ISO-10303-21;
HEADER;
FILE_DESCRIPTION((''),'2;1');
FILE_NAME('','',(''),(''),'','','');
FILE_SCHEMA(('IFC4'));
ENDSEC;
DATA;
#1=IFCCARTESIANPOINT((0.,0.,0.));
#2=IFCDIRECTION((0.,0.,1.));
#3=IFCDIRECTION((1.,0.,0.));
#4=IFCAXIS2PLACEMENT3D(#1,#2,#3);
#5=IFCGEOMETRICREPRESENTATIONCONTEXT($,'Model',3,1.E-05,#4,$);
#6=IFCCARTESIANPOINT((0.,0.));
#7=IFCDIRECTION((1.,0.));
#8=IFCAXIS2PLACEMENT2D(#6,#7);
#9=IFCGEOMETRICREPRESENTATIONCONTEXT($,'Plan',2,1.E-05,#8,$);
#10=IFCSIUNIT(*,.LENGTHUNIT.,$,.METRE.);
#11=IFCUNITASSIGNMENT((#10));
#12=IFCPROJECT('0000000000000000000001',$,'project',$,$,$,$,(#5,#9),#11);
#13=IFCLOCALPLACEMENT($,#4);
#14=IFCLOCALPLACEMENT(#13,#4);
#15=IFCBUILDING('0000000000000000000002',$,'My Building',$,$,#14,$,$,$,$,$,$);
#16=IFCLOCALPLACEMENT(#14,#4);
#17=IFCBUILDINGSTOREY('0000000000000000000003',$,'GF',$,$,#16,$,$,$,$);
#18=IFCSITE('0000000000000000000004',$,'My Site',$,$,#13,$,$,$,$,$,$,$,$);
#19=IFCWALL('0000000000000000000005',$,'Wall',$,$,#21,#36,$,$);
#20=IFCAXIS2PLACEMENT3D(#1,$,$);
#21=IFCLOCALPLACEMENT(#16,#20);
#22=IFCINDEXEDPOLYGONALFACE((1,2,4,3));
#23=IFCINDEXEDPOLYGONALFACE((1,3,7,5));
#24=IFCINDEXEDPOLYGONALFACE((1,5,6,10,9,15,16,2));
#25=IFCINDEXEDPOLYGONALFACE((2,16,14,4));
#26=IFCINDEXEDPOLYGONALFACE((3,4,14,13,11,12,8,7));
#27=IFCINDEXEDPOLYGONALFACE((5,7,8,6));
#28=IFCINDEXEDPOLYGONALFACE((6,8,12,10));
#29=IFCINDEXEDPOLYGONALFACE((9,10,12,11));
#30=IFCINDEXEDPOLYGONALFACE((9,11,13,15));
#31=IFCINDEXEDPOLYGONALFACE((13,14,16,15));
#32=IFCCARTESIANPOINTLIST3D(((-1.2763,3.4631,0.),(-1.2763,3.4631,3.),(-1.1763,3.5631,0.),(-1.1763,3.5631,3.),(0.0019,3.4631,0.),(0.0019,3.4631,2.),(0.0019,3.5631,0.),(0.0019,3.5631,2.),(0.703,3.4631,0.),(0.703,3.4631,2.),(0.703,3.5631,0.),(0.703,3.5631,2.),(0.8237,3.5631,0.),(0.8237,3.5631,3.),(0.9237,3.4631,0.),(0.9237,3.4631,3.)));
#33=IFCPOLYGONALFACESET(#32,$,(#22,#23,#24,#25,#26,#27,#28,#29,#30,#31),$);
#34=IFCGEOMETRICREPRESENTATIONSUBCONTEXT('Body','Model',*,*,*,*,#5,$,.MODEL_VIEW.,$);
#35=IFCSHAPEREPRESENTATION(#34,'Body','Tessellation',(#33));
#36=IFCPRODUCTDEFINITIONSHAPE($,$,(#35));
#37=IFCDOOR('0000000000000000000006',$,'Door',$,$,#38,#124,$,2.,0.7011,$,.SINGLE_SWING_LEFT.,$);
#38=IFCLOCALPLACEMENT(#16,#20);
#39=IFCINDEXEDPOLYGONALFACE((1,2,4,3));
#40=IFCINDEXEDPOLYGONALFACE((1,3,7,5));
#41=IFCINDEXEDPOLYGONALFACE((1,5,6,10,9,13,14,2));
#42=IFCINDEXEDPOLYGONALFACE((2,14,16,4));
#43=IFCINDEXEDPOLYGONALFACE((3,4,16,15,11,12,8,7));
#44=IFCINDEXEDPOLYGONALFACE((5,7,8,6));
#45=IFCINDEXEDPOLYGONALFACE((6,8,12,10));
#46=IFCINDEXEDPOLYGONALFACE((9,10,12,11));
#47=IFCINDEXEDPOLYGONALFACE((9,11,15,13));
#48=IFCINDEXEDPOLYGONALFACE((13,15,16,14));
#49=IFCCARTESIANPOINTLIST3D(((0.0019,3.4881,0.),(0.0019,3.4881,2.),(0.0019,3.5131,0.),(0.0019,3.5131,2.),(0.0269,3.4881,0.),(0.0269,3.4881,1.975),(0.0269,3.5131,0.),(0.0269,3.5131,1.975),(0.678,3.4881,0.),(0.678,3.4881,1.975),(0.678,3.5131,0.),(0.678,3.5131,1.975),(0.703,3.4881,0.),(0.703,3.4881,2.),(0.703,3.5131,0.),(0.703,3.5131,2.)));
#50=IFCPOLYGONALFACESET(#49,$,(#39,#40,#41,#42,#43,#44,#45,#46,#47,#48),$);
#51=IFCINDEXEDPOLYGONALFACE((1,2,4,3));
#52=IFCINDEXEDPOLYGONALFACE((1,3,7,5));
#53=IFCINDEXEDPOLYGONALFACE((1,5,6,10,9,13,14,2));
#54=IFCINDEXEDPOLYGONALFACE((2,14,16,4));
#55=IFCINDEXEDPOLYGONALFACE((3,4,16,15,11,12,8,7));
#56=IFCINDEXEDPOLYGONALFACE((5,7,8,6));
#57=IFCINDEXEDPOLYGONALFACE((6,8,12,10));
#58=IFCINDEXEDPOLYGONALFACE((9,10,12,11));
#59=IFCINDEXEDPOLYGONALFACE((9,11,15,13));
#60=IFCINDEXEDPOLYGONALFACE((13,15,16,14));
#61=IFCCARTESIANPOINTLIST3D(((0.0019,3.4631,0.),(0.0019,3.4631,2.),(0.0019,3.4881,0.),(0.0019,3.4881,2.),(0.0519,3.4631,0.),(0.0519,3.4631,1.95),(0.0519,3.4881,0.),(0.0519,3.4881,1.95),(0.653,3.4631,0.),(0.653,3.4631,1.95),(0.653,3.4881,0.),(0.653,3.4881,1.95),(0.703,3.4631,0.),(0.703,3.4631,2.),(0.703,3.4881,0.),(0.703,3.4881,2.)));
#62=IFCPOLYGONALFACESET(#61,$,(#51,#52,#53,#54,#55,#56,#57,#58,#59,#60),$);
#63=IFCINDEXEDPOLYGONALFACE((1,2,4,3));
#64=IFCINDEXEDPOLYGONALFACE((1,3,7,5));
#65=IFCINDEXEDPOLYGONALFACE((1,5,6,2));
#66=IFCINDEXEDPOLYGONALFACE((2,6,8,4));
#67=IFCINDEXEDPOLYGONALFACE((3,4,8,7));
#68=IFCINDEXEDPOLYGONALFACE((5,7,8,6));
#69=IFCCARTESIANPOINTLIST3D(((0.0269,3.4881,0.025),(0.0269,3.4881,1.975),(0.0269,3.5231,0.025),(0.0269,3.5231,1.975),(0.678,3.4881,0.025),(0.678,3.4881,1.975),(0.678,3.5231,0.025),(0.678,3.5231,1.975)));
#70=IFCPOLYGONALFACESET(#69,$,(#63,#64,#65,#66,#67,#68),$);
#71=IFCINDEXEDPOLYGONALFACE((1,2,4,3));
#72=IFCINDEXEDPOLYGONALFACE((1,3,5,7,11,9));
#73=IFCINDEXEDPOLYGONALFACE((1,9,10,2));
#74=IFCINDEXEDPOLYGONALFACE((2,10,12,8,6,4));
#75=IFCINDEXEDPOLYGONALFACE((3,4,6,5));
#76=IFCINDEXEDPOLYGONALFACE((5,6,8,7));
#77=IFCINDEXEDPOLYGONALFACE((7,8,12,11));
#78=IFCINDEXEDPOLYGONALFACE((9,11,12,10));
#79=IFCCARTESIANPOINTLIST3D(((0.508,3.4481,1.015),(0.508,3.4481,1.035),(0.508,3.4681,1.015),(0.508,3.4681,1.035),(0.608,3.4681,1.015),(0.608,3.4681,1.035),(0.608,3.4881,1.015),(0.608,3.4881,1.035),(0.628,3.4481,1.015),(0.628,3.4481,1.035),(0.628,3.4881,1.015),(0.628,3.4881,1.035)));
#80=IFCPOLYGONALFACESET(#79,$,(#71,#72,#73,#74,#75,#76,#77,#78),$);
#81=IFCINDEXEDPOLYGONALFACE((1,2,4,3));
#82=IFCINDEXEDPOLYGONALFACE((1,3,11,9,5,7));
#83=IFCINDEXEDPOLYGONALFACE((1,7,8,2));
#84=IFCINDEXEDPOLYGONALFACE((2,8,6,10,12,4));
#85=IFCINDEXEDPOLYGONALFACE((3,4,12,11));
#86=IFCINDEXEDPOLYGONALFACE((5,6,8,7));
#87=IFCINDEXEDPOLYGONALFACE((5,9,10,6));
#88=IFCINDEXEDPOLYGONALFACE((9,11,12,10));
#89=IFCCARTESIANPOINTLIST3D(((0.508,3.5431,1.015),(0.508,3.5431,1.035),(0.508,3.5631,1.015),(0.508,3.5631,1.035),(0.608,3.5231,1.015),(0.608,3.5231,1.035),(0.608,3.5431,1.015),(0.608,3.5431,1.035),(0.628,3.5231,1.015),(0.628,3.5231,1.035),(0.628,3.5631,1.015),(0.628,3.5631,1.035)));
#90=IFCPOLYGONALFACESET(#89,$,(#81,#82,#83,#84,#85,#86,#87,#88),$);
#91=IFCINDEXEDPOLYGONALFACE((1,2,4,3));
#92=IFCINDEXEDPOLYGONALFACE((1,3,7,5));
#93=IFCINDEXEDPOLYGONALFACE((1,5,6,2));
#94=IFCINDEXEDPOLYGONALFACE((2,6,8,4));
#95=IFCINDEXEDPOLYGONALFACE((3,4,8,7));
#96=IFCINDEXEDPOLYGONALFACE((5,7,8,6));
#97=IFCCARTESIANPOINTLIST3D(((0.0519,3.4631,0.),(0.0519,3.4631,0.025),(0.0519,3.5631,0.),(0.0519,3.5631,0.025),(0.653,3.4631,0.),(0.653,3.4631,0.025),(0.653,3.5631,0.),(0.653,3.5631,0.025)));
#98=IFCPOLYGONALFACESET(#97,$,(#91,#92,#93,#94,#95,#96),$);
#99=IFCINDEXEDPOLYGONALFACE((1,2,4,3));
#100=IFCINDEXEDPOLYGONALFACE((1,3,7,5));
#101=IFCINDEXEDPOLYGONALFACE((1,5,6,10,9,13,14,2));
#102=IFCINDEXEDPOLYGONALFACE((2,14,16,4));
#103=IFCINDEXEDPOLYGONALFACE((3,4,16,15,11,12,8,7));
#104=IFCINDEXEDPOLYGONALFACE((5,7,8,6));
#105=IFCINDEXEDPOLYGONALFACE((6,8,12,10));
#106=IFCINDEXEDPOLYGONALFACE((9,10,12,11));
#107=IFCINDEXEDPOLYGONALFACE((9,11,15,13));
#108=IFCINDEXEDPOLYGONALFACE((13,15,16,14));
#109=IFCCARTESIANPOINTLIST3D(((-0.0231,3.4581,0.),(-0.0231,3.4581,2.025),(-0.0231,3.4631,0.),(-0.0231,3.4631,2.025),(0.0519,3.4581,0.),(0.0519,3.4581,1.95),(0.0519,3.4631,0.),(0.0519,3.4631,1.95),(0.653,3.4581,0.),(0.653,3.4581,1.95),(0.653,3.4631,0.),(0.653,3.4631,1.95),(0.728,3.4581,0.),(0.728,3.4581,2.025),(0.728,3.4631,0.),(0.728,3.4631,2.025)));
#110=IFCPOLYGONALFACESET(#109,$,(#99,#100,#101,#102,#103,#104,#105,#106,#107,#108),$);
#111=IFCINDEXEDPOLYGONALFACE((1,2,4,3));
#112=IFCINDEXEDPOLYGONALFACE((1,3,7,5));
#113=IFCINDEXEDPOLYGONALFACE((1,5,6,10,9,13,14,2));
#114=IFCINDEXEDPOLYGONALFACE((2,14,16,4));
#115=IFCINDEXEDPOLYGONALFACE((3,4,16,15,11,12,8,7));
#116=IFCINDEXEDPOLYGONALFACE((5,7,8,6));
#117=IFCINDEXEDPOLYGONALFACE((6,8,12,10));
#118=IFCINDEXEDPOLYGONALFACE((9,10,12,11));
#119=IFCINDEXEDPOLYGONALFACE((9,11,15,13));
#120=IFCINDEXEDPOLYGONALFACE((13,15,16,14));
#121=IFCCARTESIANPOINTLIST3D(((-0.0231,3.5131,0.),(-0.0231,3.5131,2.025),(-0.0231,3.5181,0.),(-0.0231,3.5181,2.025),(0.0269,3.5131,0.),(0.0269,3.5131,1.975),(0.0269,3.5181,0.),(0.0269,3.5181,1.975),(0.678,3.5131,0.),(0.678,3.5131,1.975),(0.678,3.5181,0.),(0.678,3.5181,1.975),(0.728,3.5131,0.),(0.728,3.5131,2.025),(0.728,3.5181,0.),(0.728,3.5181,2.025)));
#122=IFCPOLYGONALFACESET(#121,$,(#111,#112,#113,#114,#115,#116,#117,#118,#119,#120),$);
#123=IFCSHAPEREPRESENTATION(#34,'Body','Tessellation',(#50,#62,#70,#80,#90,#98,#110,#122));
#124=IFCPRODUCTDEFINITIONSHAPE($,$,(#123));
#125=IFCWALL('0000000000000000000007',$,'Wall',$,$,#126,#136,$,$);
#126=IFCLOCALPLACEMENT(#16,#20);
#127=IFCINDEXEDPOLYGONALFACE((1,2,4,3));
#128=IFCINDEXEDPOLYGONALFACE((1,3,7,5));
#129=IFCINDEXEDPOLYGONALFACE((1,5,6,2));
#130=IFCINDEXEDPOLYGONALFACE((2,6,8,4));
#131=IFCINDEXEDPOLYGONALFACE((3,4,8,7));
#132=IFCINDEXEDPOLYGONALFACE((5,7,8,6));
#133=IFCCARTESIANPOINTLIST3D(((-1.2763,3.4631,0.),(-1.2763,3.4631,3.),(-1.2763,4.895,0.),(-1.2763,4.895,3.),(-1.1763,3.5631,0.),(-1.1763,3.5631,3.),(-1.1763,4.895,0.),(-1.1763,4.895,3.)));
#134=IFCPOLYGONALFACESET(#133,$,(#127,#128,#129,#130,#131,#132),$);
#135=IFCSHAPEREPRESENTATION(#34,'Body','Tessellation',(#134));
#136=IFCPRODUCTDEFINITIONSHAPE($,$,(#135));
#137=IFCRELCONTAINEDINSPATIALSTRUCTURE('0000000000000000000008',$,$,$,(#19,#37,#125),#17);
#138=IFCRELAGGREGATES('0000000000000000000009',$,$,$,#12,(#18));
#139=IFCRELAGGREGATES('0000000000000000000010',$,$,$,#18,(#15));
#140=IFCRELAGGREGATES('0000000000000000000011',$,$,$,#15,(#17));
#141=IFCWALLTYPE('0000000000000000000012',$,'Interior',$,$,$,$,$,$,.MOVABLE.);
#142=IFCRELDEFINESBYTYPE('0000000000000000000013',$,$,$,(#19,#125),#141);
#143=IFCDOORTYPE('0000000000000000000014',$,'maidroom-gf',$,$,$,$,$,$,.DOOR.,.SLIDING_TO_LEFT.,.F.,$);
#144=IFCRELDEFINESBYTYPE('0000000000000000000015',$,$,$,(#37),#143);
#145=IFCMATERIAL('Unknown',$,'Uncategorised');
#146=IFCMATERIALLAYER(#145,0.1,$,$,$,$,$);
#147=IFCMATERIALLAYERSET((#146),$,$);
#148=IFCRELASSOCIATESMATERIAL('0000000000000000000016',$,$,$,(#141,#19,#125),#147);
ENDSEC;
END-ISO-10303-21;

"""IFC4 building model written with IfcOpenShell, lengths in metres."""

from ifc_helpers import new_model, entity, si_unit, frame, origin_with_axes, origin_2d_with_axis, place, context, subcontext, project, spatial, line, indexed_curve, outline, extrude, shape, source, transform, mapped, material, layer, layer_set, layer_usage, type_object, type_shapes, element, fill, save


model = new_model("IFC4")

# Units and contexts
model_context = context("Model", 3, precision=1e-05, world=origin_with_axes())
plan_context = context("Plan", 2, precision=1e-05, world=origin_2d_with_axis())
body_context_1 = subcontext(model_context, "Body", "Model", "MODEL_VIEW")
body_context_2 = subcontext(plan_context, "Body", "Plan", "PLAN_VIEW")
ifc_project = project(units=[si_unit("LENGTHUNIT", "METRE")], contexts=[model_context, plan_context])

# Site, building, storey
site_placement = place(None, origin_with_axes())
site = spatial("IfcSite", under=ifc_project, at=site_placement, Name="My Site")
building_placement = place(site_placement, origin_with_axes())
building = spatial("IfcBuilding", under=site, at=building_placement, Name="My Building")
storey_placement = place(building_placement, origin_with_axes())
storey = spatial("IfcBuildingStorey", under=building, at=storey_placement, Name="GF")

# Shared definitions
ifc_material = material(Name="Unknown", Category="Uncategorised")

# Shared definitions
ifc_layer_1 = layer(ifc_material, 0.1)
ifc_layer_set_1 = layer_set([ifc_layer_1])
wall_type_1 = type_object("IfcWallType", Name="Interior", PredefinedType="MOVABLE", material=ifc_layer_set_1)

# Wall, opening, door
ifc_layer_usage_1 = layer_usage(ifc_layer_set_1, "AXIS2", "POSITIVE", 0.0)
wall_1_placement = place(storey_placement, frame((0.8237, 3.5631, 0.0), z_axis=(0.0, 0.0, 1.0), x_axis=(-1.0, 0.0, 0.0)))
wall_1 = element("IfcWall", 1, at=wall_1_placement, inside=storey, type_object=wall_type_1, material=ifc_layer_usage_1, Name="Wall", context=body_context_1, shape_type="SweptSolid", body=[
    extrude(outline(indexed_curve([(0.0, 0.0), (-0.1, 0.1), (2.1, 0.1), (2.0, 0.0)], segments=[line(1, 2, 3, 4, 1)])), origin_with_axes(), (0.0, 0.0, 1.0), 3.0),
])
shared_shape_1 = source(origin_with_axes(), body_context_1, "Body", "SweptSolid", [
    extrude(outline(indexed_curve([(0.0, 0.0), (0.7011, 0.0), (0.7011, 2.0), (0.0, 2.0)], segments=[line(1, 2, 3, 4, 1)])), frame((0.0, -0.6, 0.0), z_axis=(0.0, -1.0, 0.0), x_axis=(1.0, 0.0, 0.0)), (0.0, 0.0, -1.0), 1.2),
])
opening_1_placement = place(wall_1_placement, frame((0.8218, 0.1, 0.0), z_axis=(0.0, 0.0, 1.0), x_axis=(-1.0, 0.0, 0.0)))
opening_1 = element("IfcOpeningElement", 2, at=opening_1_placement, cuts=wall_1, PredefinedType="OPENING", context=body_context_1, shape_type="MappedRepresentation", body=[
    mapped(shared_shape_1, transform((0.0, 0.0, 0.0), x_axis=(1.0, 0.0, 0.0), y_axis=(0.0, 1.0, 0.0), z_axis=(0.0, 0.0, 1.0), scale=1.0)),
])
door_type_1 = type_object("IfcDoorType", Name="maidroom-gf", OperationType="SLIDING_TO_LEFT", ParameterTakesPrecedence=False, PredefinedType="DOOR")
shared_shape_2 = source(origin_with_axes(), body_context_1, "Body", "SweptSolid", [
    extrude(outline(indexed_curve([(0.0, 0.0), (0.0, 2.0), (0.7011, 2.0), (0.7011, 0.0), (0.6761, 0.0), (0.6761, 1.975), (0.025, 1.975), (0.025, 0.0)], segments=[line(1, 2, 3, 4, 5, 6, 7, 8, 1)])), frame((0.0, 0.025, 0.0), z_axis=(0.0, -1.0, 0.0), x_axis=(1.0, 0.0, 0.0)), (0.0, 0.0, -1.0), 0.025),
    extrude(outline(indexed_curve([(0.0, 0.0), (0.0, 2.0), (0.7011, 2.0), (0.7011, 0.0), (0.6511, 0.0), (0.6511, 1.95), (0.05, 1.95), (0.05, 0.0)], segments=[line(1, 2, 3, 4, 5, 6, 7, 8, 1)])), frame((0.0, 0.0, 0.0), z_axis=(0.0, -1.0, 0.0), x_axis=(1.0, 0.0, 0.0)), (0.0, 0.0, -1.0), 0.025),
    extrude(outline(indexed_curve([(0.0, 0.0), (0.6511, 0.0), (0.6511, 0.035), (0.0, 0.035)], segments=[line(1, 2, 3, 4, 1)])), frame((0.025, 0.025, 0.025), z_axis=(0.0, 0.0, 1.0), x_axis=(1.0, 0.0, 0.0)), (0.0, 0.0, 1.0), 1.95),
    extrude(outline(indexed_curve([(0.0, 0.0), (0.0, -0.04), (-0.12, -0.04), (-0.12, -0.02), (-0.02, -0.02), (-0.02, 0.0)], segments=[line(1, 2, 3, 4, 5, 6, 1)])), frame((0.6261, 0.025, 1.015), z_axis=(0.0, 0.0, 1.0), x_axis=(1.0, 0.0, 0.0)), (0.0, 0.0, 1.0), 0.02),
    extrude(outline(indexed_curve([(0.0, 0.0), (0.0, 0.04), (-0.12, 0.04), (-0.12, 0.02), (-0.02, 0.02), (-0.02, 0.0)], segments=[line(1, 2, 3, 4, 5, 6, 1)])), frame((0.6261, 0.06, 1.015), z_axis=(0.0, 0.0, 1.0), x_axis=(1.0, 0.0, 0.0)), (0.0, 0.0, 1.0), 0.02),
    extrude(outline(indexed_curve([(0.0, 0.0), (0.6011, 0.0), (0.6011, 0.1), (0.0, 0.1)], segments=[line(1, 2, 3, 4, 1)])), frame((0.05, 0.0, 0.0), z_axis=(0.0, 0.0, 1.0), x_axis=(1.0, 0.0, 0.0)), (0.0, 0.0, 1.0), 0.025),
    extrude(outline(indexed_curve([(0.0, 0.0), (0.0, 2.025), (0.7511, 2.025), (0.7511, 0.0), (0.6761, 0.0), (0.6761, 1.95), (0.075, 1.95), (0.075, 0.0)], segments=[line(1, 2, 3, 4, 5, 6, 7, 8, 1)])), frame((-0.025, -0.005, 0.0), z_axis=(0.0, -1.0, 0.0), x_axis=(1.0, 0.0, 0.0)), (0.0, 0.0, -1.0), 0.005),
    extrude(outline(indexed_curve([(0.0, 0.0), (0.0, 2.025), (0.7511, 2.025), (0.7511, 0.0), (0.7011, 0.0), (0.7011, 1.975), (0.05, 1.975), (0.05, 0.0)], segments=[line(1, 2, 3, 4, 5, 6, 7, 8, 1)])), frame((-0.025, 0.05, 0.0), z_axis=(0.0, -1.0, 0.0), x_axis=(1.0, 0.0, 0.0)), (0.0, 0.0, -1.0), 0.005),
])
shared_shape_3 = source(origin_with_axes(), body_context_2, "Body", "Curve2D", [
    entity("IfcIndexedPolyCurve", entity("IfcCartesianPointList2D", [[0.0, 0.0], [0.0, 0.05], [0.025, 0.05], [0.025, 0.025], [0.05, 0.025], [0.05, 0.0]]), [entity("IfcLineIndex", [1, 2, 3, 4, 5, 6, 1])]),
    entity("IfcIndexedPolyCurve", entity("IfcCartesianPointList2D", [[0.7011, 0.0], [0.7011, 0.05], [0.6761, 0.05], [0.6761, 0.025], [0.6511, 0.025], [0.6511, 0.0]]), [entity("IfcLineIndex", [1, 2, 3, 4, 5, 6, 1])]),
    entity("IfcTrimmedCurve", entity("IfcEllipse", entity("IfcAxis2Placement2D", entity("IfcCartesianPoint", [0.06, 0.05]), entity("IfcDirection", [1.0, 0.0])), 0.6161, 0.6511), [entity("IfcCartesianPoint", [0.6761, 0.05])], [entity("IfcCartesianPoint", [0.06, 0.7011])], True, "CARTESIAN"),
    entity("IfcIndexedPolyCurve", entity("IfcCartesianPointList2D", [[0.025, 0.05], [0.06, 0.05], [0.06, 0.7011], [0.025, 0.7011]]), [entity("IfcLineIndex", [1, 2, 3, 4, 1])]),
])
type_shapes(door_type_1, [shared_shape_2, shared_shape_3])
door_1_placement = place(opening_1_placement, frame((0.0, 0.0, 0.0), z_axis=(0.0, 0.0, 1.0), x_axis=(1.0, 0.0, 0.0)))
door_1 = element("IfcDoor", 3, at=door_1_placement, inside=storey, type_object=door_type_1, Name="Door", OperationType="SINGLE_SWING_LEFT", OverallHeight=2.0, OverallWidth=0.7011, shapes=[
    shape(body_context_1, "Body", "MappedRepresentation", [mapped(shared_shape_2, transform((0.0, 0.0, 0.0), x_axis=(1.0, 0.0, 0.0), y_axis=(0.0, 1.0, 0.0), z_axis=(0.0, 0.0, 1.0), scale=1.0))]),
    shape(body_context_2, "Body", "MappedRepresentation", [mapped(shared_shape_3, transform((0.0, 0.0, 0.0), x_axis=(1.0, 0.0, 0.0), y_axis=(0.0, 1.0, 0.0), z_axis=(0.0, 0.0, 1.0), scale=1.0))]),
])
fill(opening_1, door_1)

# Wall
ifc_layer_usage_2 = layer_usage(ifc_layer_set_1, "AXIS2", "POSITIVE", 0.0)
wall_2_placement = place(storey_placement, frame((-1.1763, 3.5631, 0.0), z_axis=(0.0, 0.0, 1.0), x_axis=(0.0, 1.0, 0.0)))
element("IfcWall", 4, at=wall_2_placement, inside=storey, type_object=wall_type_1, material=ifc_layer_usage_2, Name="Wall", context=body_context_1, shape_type="SweptSolid", body=[
    extrude(outline(indexed_curve([(0.0, 0.0), (-0.1, 0.1), (1.3318, 0.1), (1.3318, 0.0)], segments=[line(1, 2, 3, 4, 1)])), origin_with_axes(), (0.0, 0.0, 1.0), 3.0),
])

save(model, "model.ifc")
